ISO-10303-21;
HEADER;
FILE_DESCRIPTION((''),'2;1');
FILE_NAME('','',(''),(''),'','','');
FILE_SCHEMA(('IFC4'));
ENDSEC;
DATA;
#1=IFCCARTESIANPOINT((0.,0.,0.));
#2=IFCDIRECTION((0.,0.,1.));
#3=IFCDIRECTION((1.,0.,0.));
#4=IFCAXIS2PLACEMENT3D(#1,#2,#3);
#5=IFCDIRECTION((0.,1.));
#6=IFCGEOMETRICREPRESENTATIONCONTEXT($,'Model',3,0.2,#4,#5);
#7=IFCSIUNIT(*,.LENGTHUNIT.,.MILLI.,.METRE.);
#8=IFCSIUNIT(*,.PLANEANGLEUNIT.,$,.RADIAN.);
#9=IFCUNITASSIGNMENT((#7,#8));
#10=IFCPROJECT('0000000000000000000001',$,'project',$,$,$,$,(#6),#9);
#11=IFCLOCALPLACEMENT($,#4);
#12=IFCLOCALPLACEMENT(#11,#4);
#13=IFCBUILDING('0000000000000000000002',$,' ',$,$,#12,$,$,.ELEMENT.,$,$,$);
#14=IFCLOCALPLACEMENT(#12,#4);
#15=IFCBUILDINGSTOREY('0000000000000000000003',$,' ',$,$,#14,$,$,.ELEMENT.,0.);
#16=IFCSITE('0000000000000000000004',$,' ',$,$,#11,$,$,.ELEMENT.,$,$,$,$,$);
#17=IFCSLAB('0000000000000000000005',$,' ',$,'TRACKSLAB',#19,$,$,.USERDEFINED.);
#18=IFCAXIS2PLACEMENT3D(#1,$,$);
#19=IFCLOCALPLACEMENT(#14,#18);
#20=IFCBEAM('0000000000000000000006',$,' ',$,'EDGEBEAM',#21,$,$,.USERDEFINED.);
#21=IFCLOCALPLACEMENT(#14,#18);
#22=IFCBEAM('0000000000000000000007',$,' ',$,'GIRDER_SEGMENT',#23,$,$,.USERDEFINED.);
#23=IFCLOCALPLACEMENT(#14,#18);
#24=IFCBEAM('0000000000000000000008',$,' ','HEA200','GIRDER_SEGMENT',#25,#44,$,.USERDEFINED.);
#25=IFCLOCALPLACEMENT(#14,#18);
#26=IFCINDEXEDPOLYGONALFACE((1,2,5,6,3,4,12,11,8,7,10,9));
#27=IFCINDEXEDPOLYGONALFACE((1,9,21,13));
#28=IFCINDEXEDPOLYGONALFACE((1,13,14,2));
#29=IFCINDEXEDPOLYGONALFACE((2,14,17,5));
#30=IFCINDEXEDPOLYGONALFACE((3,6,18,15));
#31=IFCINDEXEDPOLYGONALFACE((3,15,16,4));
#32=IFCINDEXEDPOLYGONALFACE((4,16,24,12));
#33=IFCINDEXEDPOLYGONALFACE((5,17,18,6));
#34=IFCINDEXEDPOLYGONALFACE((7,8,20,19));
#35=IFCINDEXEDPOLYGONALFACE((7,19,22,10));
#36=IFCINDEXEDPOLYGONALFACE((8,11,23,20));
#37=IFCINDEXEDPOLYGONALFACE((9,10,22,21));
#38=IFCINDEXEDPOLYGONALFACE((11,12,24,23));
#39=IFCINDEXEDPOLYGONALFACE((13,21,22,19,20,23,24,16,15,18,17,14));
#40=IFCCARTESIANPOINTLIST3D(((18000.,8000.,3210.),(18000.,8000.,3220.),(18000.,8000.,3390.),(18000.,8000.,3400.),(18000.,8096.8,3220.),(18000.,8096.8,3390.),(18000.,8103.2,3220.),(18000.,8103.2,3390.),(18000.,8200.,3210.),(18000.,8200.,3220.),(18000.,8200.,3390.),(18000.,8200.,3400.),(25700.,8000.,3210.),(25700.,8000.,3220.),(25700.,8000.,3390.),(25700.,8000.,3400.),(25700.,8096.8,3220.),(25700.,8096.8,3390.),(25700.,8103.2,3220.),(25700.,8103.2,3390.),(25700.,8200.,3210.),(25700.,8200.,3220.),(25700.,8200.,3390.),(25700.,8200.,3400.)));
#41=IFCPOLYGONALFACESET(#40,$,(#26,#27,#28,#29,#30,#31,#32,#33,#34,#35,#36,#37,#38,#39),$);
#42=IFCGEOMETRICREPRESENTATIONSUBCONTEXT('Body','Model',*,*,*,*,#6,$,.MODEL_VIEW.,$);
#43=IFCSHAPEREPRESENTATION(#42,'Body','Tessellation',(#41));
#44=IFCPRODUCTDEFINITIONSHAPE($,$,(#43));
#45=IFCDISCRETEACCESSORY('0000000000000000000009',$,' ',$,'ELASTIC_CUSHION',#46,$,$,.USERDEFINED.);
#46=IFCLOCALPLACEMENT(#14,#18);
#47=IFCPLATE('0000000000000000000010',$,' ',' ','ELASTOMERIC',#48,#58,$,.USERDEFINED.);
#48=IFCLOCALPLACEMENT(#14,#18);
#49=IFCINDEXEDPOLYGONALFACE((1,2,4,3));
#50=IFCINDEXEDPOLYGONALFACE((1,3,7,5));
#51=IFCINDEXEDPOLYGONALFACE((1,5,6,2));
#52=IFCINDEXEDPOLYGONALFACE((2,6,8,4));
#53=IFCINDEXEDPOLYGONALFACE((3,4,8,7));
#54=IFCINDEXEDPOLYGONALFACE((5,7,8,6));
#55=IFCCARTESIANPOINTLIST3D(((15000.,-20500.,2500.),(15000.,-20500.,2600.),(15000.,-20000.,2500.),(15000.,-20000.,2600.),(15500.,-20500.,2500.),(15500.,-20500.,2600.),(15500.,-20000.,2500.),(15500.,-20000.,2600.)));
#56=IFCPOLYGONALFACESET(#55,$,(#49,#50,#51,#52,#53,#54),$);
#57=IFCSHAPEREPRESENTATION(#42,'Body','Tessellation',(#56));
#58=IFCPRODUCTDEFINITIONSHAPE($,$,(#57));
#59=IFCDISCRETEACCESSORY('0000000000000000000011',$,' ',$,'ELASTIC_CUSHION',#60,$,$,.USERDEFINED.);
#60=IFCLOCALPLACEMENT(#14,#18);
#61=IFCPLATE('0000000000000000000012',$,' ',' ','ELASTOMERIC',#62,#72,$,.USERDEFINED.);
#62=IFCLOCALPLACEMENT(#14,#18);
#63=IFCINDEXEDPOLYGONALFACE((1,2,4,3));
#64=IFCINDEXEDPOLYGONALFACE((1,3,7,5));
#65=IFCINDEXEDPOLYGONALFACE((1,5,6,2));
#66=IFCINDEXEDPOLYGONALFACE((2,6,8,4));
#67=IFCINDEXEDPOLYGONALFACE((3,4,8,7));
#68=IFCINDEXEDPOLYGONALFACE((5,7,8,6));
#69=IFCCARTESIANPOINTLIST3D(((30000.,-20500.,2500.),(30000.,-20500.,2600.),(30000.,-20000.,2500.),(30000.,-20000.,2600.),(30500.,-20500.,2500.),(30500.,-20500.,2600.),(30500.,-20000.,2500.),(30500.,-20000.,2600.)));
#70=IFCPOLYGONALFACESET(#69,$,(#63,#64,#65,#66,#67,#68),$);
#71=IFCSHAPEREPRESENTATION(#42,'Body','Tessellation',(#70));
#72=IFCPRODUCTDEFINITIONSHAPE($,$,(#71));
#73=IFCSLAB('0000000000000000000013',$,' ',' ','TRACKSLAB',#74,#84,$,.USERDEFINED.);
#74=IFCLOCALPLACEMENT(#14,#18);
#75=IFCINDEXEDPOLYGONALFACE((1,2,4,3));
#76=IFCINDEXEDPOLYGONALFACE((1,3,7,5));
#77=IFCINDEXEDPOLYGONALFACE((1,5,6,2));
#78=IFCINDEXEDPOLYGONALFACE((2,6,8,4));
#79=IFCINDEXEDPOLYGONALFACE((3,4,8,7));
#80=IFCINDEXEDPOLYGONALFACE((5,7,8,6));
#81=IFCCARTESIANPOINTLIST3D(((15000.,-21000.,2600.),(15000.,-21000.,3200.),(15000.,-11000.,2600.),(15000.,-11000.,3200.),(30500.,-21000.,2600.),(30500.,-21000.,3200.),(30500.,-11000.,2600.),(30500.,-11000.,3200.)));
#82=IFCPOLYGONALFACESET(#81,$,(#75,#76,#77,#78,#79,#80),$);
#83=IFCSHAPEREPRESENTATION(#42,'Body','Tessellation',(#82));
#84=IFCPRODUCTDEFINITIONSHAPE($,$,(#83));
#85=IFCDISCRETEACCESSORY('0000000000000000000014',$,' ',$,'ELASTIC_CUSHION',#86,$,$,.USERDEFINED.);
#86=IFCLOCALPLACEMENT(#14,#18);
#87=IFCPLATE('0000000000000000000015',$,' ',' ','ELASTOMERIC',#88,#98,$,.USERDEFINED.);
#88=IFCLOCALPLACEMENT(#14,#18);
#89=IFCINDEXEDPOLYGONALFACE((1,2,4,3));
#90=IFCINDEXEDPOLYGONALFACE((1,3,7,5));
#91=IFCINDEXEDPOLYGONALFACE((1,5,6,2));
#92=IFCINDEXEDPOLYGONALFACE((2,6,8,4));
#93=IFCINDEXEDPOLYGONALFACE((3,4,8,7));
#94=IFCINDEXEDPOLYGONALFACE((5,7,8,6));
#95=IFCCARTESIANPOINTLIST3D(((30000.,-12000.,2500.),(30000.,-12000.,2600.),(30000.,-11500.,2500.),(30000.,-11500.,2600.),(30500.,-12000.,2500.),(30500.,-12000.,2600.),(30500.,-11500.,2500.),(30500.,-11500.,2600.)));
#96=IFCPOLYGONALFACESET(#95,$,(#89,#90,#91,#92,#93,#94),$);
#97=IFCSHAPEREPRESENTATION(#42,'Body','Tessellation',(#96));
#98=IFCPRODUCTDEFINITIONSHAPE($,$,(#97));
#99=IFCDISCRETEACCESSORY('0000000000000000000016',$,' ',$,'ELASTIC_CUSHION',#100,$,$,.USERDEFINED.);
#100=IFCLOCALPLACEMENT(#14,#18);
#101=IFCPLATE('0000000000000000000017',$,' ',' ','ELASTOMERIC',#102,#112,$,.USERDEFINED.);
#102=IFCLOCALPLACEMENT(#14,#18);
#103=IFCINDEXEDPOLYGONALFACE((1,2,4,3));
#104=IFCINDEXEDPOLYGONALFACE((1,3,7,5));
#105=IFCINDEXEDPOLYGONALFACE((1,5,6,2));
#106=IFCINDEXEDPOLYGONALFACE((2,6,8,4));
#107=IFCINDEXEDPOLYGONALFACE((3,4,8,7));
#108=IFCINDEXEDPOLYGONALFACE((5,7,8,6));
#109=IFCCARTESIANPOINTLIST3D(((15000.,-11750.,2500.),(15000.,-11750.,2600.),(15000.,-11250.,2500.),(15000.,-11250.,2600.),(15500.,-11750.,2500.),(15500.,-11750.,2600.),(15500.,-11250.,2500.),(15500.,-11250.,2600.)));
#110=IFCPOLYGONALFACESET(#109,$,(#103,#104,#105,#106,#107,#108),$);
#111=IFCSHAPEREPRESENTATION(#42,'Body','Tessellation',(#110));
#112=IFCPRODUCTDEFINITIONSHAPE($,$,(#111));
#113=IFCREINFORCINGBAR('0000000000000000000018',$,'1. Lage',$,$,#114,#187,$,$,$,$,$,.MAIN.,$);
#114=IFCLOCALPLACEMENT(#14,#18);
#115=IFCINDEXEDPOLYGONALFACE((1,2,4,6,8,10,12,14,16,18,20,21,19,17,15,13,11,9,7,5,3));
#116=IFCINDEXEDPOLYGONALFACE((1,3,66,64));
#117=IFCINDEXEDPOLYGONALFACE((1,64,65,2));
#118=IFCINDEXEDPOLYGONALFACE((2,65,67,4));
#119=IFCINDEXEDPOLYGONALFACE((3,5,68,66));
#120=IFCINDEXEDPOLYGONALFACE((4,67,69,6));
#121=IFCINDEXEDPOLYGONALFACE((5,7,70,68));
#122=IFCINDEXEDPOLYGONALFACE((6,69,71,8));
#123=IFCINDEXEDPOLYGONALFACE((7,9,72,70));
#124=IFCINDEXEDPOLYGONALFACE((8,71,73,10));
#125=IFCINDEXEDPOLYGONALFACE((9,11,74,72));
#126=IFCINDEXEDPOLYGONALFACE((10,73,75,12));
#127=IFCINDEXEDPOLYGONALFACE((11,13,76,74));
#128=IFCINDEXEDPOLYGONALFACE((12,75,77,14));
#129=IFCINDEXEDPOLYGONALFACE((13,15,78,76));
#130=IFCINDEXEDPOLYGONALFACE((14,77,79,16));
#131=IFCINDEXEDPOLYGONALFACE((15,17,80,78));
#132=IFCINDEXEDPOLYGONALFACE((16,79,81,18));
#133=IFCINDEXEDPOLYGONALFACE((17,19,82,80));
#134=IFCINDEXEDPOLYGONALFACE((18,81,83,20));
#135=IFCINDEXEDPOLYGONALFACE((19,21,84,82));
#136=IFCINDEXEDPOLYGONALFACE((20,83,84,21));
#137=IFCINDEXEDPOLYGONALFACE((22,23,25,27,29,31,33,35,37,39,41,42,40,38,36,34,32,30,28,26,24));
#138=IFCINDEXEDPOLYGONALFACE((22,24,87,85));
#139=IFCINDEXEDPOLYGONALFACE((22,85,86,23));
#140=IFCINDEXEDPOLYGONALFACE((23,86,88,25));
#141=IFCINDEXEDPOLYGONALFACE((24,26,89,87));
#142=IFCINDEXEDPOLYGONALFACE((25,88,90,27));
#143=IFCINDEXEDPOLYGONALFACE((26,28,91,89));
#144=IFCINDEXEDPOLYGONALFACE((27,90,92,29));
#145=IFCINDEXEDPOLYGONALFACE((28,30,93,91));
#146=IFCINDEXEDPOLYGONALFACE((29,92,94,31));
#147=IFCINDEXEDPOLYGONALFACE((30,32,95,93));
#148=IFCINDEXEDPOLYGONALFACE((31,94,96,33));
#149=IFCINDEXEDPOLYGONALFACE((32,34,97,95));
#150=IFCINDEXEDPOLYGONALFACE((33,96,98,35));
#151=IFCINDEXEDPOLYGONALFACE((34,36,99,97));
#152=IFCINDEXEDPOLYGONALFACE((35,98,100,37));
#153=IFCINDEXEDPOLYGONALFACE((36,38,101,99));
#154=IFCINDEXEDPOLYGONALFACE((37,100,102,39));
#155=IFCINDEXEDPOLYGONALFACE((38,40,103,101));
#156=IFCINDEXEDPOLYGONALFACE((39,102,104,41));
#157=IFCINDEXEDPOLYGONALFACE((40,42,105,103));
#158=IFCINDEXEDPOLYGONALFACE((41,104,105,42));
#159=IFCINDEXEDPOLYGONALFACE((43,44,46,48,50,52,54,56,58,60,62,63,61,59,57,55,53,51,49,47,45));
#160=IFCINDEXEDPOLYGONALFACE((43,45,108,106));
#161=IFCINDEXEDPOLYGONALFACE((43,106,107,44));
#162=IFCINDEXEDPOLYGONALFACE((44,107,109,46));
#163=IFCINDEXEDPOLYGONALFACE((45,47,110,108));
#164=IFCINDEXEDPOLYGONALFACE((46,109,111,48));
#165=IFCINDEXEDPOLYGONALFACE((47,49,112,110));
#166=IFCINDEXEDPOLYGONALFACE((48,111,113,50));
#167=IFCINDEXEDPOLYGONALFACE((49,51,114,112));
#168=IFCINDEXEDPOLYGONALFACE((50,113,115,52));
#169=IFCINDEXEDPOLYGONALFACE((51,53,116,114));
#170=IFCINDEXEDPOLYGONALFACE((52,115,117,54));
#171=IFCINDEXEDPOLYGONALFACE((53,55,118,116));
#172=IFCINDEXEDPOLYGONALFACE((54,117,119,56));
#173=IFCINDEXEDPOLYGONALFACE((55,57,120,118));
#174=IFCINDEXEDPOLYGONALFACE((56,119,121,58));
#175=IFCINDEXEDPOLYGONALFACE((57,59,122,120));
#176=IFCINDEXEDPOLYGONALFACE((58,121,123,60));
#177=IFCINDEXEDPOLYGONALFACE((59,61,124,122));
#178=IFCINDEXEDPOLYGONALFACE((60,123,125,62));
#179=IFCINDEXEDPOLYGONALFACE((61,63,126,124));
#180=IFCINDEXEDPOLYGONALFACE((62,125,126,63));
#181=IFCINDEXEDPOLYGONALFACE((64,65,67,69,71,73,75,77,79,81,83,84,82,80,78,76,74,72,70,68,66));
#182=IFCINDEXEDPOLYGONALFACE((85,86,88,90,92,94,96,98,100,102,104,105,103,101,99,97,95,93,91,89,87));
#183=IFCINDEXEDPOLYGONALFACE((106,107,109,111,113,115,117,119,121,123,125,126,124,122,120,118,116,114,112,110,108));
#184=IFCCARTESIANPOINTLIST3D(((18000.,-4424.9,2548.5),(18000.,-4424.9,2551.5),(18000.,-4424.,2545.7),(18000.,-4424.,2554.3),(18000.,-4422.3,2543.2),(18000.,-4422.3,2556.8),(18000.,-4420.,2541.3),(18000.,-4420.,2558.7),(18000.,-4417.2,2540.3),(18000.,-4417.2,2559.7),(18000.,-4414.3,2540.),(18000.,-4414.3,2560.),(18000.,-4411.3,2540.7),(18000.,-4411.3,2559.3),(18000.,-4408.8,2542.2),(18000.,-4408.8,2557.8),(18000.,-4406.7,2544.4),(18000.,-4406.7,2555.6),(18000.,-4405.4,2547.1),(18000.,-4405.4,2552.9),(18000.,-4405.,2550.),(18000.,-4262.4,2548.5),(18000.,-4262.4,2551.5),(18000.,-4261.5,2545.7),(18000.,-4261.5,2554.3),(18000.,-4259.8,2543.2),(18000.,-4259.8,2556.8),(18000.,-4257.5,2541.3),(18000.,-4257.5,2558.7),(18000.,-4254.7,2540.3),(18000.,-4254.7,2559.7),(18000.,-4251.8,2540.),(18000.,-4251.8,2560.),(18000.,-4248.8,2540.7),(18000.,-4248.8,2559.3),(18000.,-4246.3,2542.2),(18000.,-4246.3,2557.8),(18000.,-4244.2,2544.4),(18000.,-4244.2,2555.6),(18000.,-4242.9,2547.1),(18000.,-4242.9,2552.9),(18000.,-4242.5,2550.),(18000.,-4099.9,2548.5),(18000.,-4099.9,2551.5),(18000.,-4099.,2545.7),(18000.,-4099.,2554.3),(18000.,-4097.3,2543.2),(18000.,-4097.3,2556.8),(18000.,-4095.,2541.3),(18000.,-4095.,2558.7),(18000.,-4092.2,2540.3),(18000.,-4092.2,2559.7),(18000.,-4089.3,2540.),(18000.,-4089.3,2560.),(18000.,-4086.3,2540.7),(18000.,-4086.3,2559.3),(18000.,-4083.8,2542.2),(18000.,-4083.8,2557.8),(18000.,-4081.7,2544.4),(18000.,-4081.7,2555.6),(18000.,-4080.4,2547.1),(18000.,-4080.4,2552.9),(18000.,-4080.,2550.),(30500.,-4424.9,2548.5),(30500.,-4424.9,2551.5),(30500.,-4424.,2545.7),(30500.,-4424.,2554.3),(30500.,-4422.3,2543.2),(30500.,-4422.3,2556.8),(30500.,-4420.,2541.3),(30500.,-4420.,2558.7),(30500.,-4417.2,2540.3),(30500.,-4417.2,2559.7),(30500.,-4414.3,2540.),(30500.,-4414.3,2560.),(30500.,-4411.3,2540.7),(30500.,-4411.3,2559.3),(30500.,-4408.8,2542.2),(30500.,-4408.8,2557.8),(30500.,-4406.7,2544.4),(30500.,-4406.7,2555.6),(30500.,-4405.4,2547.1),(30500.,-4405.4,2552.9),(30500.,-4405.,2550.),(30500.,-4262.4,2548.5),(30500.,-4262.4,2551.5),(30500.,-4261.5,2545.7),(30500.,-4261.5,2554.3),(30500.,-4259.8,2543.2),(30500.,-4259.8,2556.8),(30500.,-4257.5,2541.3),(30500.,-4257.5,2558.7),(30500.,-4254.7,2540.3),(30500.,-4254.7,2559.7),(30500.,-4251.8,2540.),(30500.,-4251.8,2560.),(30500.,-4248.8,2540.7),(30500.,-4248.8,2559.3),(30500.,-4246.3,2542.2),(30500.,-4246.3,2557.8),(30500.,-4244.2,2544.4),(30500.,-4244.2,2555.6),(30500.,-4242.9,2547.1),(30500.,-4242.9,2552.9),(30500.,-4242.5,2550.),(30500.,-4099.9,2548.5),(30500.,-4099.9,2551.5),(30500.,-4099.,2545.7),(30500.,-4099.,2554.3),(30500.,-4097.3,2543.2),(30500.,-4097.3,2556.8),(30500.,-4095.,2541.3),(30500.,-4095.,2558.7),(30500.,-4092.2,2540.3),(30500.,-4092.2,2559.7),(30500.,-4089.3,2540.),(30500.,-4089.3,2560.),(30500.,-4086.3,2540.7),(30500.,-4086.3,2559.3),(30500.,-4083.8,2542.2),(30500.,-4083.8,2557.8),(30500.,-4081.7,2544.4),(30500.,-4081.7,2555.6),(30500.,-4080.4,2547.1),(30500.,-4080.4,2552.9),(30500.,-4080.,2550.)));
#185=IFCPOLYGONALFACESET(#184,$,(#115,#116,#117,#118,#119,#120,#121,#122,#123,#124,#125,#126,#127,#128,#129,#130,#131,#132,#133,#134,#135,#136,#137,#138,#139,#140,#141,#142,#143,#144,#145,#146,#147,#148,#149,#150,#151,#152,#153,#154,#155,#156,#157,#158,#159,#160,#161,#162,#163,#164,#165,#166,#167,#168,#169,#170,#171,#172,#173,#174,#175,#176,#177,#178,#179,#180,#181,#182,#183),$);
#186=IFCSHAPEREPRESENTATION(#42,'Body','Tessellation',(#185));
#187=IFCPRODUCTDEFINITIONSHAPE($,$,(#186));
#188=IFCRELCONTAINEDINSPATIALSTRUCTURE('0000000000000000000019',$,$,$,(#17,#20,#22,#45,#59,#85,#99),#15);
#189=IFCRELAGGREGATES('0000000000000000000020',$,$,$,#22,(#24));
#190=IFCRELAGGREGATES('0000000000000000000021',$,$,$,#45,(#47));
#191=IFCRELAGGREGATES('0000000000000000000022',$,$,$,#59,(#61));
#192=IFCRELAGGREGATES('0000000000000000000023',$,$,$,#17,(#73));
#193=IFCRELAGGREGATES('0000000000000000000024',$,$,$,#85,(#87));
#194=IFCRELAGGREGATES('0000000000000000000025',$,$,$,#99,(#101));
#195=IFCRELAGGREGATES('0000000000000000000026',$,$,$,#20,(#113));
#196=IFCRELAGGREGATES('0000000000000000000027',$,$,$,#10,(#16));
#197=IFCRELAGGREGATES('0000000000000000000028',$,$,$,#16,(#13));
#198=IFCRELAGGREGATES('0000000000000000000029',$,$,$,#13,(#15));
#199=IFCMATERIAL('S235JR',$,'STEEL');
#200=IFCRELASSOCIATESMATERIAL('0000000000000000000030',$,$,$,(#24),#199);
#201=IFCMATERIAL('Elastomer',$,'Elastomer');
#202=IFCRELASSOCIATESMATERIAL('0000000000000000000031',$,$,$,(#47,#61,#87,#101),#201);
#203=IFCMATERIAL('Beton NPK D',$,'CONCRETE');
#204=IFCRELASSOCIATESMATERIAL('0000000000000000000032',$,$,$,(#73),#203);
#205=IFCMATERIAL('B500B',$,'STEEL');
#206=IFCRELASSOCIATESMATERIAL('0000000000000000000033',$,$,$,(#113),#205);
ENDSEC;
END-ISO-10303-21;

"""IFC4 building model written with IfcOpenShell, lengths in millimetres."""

from ifc_helpers import new_model, entity, si_unit, direction, frame, origin_with_axes, place, context, subcontext, project, spatial, line, indexed_curve, outline, extrude, source, transform, mapped, material, element, aggregate, save


model = new_model("IFC4")

# Units and contexts
model_context = context("Model", 3, precision=0.2, world=origin_with_axes(), true_north=direction((0.0, 1.0)))
body_context = subcontext(model_context, "Body", "Model", "MODEL_VIEW")
ifc_project = project(units=[si_unit("LENGTHUNIT", "METRE", prefix="MILLI"), si_unit("PLANEANGLEUNIT", "RADIAN")], contexts=[model_context])

# Site, building, storey
site_placement = place(None, origin_with_axes())
site = spatial("IfcSite", under=ifc_project, at=site_placement, Name=" ", CompositionType="ELEMENT")
building_placement = place(site_placement, origin_with_axes())
building = spatial("IfcBuilding", under=site, at=building_placement, Name=" ", CompositionType="ELEMENT")
storey_placement = place(building_placement, origin_with_axes())
storey = spatial("IfcBuildingStorey", under=building, at=storey_placement, Name=" ", CompositionType="ELEMENT", Elevation=0.0)

# Slab
slab_1_placement = place(storey_placement, frame((30500.0, -11000.0, 2900.0), z_axis=(0.0, 0.0, 1.0), x_axis=(-1.0, 0.0, 0.0)))
slab_1 = element("IfcSlab", 1, at=slab_1_placement, inside=storey, Name=" ", ObjectType="TRACKSLAB", PredefinedType="USERDEFINED")
ifc_material_1 = material(Name="B500B", Category="STEEL")

# Beams
beam_1_placement = place(storey_placement, frame((30500.0, -4250.0, 2950.0), z_axis=(0.0, 1.0, 0.0), x_axis=(-1.0, 0.0, 0.0)))
beam_1 = element("IfcBeam", 2, at=beam_1_placement, inside=storey, Name=" ", ObjectType="EDGEBEAM", PredefinedType="USERDEFINED")
ifc_material_2 = material(Name="S235JR", Category="STEEL")
beam_2_placement = place(storey_placement, frame((18000.0, 8100.0, 3305.0), z_axis=(0.0, -1.0, 0.0), x_axis=(1.0, 0.0, 0.0)))
beam_2 = element("IfcBeam", 3, at=beam_2_placement, inside=storey, Name=" ", ObjectType="GIRDER_SEGMENT", PredefinedType="USERDEFINED")
beam_3_placement = place(beam_2_placement, origin_with_axes())
beam_3 = element("IfcBeam", 4, at=beam_3_placement, material=ifc_material_2, Name=" ", Description="HEA200", ObjectType="GIRDER_SEGMENT", PredefinedType="USERDEFINED", context=body_context, shape_type="SolidModel", body=[
    extrude(outline(indexed_curve([(-100.0, -95.0), (100.0, -95.0), (100.0, -85.0), (3.2, -85.0), (3.2, 85.0), (100.0, 85.0), (100.0, 95.0), (-100.0, 95.0), (-100.0, 85.0), (-3.2, 85.0), (-3.2, -85.0), (-100.0, -85.0)], segments=[line(1, 2, 3, 4, 5, 6, 7, 8, 9, 10, 11, 12, 1)])), frame((0.0, 0.0, 0.0), z_axis=(-1.0, 0.0, 0.0), x_axis=(0.0, 0.0, 1.0)), (0.0, 0.0, -1.0), 7700.0),
])
aggregate(beam_2, [beam_3])

# Discrete accessories, plates
discrete_accessory_1_placement = place(storey_placement, frame((15000.0, -20500.0, 2550.0), z_axis=(0.0, 0.0, 1.0), x_axis=(1.0, 0.0, 0.0)))
discrete_accessory_1 = element("IfcDiscreteAccessory", 5, at=discrete_accessory_1_placement, inside=storey, Name=" ", ObjectType="ELASTIC_CUSHION", PredefinedType="USERDEFINED")
ifc_material_3 = material(Name="Elastomer", Category="Elastomer")
plate_1_placement = place(discrete_accessory_1_placement, origin_with_axes())
plate_1 = element("IfcPlate", 6, at=plate_1_placement, material=ifc_material_3, Name=" ", Description=" ", ObjectType="ELASTOMERIC", PredefinedType="USERDEFINED", context=body_context, shape_type="SolidModel", body=[
    extrude(outline(indexed_curve([(0.0, 0.0), (500.0, 0.0), (500.0, 500.0), (0.0, 500.0)], segments=[line(1, 2, 3, 4, 1)])), frame((0.0, 0.0, 50.0), z_axis=(0.0, 0.0, 1.0), x_axis=(1.0, 0.0, 0.0)), (0.0, 0.0, -1.0), 100.0),
])
aggregate(discrete_accessory_1, [plate_1])
discrete_accessory_2_placement = place(storey_placement, frame((30000.0, -20500.0, 2550.0), z_axis=(0.0, 0.0, 1.0), x_axis=(1.0, 0.0, 0.0)))
discrete_accessory_2 = element("IfcDiscreteAccessory", 7, at=discrete_accessory_2_placement, inside=storey, Name=" ", ObjectType="ELASTIC_CUSHION", PredefinedType="USERDEFINED")
plate_2_placement = place(discrete_accessory_2_placement, origin_with_axes())
plate_2 = element("IfcPlate", 8, at=plate_2_placement, material=ifc_material_3, Name=" ", Description=" ", ObjectType="ELASTOMERIC", PredefinedType="USERDEFINED", context=body_context, shape_type="SolidModel", body=[
    extrude(outline(indexed_curve([(0.0, 0.0), (500.0, 0.0), (500.0, 500.0), (0.0, 500.0)], segments=[line(1, 2, 3, 4, 1)])), frame((0.0, 0.0, 50.0), z_axis=(0.0, 0.0, 1.0), x_axis=(1.0, 0.0, 0.0)), (0.0, 0.0, -1.0), 100.0),
])
aggregate(discrete_accessory_2, [plate_2])

# Slab
ifc_material_4 = material(Name="Beton NPK D", Category="CONCRETE")
slab_2_placement = place(slab_1_placement, origin_with_axes())
slab_2 = element("IfcSlab", 9, at=slab_2_placement, material=ifc_material_4, Name=" ", Description=" ", ObjectType="TRACKSLAB", PredefinedType="USERDEFINED", context=body_context, shape_type="SolidModel", body=[
    extrude(outline(indexed_curve([(0.0, 0.0), (15500.0, 0.0), (15500.0, 10000.0), (0.0, 10000.0)], segments=[line(1, 2, 3, 4, 1)])), frame((0.0, 0.0, 300.0), z_axis=(0.0, 0.0, 1.0), x_axis=(1.0, 0.0, 0.0)), (0.0, 0.0, -1.0), 600.0),
])
aggregate(slab_1, [slab_2])

# Discrete accessories, plates
discrete_accessory_3_placement = place(storey_placement, frame((30000.0, -12000.0, 2550.0), z_axis=(0.0, 0.0, 1.0), x_axis=(1.0, 0.0, 0.0)))
discrete_accessory_3 = element("IfcDiscreteAccessory", 10, at=discrete_accessory_3_placement, inside=storey, Name=" ", ObjectType="ELASTIC_CUSHION", PredefinedType="USERDEFINED")
plate_3_placement = place(discrete_accessory_3_placement, origin_with_axes())
plate_3 = element("IfcPlate", 11, at=plate_3_placement, material=ifc_material_3, Name=" ", Description=" ", ObjectType="ELASTOMERIC", PredefinedType="USERDEFINED", context=body_context, shape_type="SolidModel", body=[
    extrude(outline(indexed_curve([(0.0, 0.0), (500.0, 0.0), (500.0, 500.0), (0.0, 500.0)], segments=[line(1, 2, 3, 4, 1)])), frame((0.0, 0.0, 50.0), z_axis=(0.0, 0.0, 1.0), x_axis=(1.0, 0.0, 0.0)), (0.0, 0.0, -1.0), 100.0),
])
aggregate(discrete_accessory_3, [plate_3])
discrete_accessory_4_placement = place(storey_placement, frame((15000.0, -11750.0, 2550.0), z_axis=(0.0, 0.0, 1.0), x_axis=(1.0, 0.0, 0.0)))
discrete_accessory_4 = element("IfcDiscreteAccessory", 12, at=discrete_accessory_4_placement, inside=storey, Name=" ", ObjectType="ELASTIC_CUSHION", PredefinedType="USERDEFINED")
plate_4_placement = place(discrete_accessory_4_placement, origin_with_axes())
plate_4 = element("IfcPlate", 13, at=plate_4_placement, material=ifc_material_3, Name=" ", Description=" ", ObjectType="ELASTOMERIC", PredefinedType="USERDEFINED", context=body_context, shape_type="SolidModel", body=[
    extrude(outline(indexed_curve([(0.0, 0.0), (500.0, 0.0), (500.0, 500.0), (0.0, 500.0)], segments=[line(1, 2, 3, 4, 1)])), frame((0.0, 0.0, 50.0), z_axis=(0.0, 0.0, 1.0), x_axis=(1.0, 0.0, 0.0)), (0.0, 0.0, -1.0), 100.0),
])
aggregate(discrete_accessory_4, [plate_4])

# Reinforcing bar
shared_shape_1 = source(origin_with_axes(), body_context, "Body", "AdvancedSweptSolid", [
    entity("IfcSweptDiskSolid", entity("IfcIndexedPolyCurve", entity("IfcCartesianPointList3D", [[0.0, 0.0, 0.0], [12500.0, 0.0, 0.0]]), [entity("IfcLineIndex", [1, 2])]), 10.0),
])
reinforcing_bar_1_placement = place(beam_1_placement, frame((0.0, -400.0, -165.0), z_axis=(0.0, 0.0, 1.0), x_axis=(1.0, 0.0, 0.0)))
reinforcing_bar_1 = element("IfcReinforcingBar", 14, at=reinforcing_bar_1_placement, material=ifc_material_1, Name="1. Lage", PredefinedType="MAIN", context=body_context, shape_type="MappedRepresentation", body=[
    mapped(shared_shape_1, transform((0.0, 0.0, 0.0))),
    mapped(shared_shape_1, transform((0.0, 0.0, 162.5))),
    mapped(shared_shape_1, transform((0.0, 0.0, 325.0))),
])
aggregate(beam_1, [reinforcing_bar_1])

save(model, "model.ifc")
